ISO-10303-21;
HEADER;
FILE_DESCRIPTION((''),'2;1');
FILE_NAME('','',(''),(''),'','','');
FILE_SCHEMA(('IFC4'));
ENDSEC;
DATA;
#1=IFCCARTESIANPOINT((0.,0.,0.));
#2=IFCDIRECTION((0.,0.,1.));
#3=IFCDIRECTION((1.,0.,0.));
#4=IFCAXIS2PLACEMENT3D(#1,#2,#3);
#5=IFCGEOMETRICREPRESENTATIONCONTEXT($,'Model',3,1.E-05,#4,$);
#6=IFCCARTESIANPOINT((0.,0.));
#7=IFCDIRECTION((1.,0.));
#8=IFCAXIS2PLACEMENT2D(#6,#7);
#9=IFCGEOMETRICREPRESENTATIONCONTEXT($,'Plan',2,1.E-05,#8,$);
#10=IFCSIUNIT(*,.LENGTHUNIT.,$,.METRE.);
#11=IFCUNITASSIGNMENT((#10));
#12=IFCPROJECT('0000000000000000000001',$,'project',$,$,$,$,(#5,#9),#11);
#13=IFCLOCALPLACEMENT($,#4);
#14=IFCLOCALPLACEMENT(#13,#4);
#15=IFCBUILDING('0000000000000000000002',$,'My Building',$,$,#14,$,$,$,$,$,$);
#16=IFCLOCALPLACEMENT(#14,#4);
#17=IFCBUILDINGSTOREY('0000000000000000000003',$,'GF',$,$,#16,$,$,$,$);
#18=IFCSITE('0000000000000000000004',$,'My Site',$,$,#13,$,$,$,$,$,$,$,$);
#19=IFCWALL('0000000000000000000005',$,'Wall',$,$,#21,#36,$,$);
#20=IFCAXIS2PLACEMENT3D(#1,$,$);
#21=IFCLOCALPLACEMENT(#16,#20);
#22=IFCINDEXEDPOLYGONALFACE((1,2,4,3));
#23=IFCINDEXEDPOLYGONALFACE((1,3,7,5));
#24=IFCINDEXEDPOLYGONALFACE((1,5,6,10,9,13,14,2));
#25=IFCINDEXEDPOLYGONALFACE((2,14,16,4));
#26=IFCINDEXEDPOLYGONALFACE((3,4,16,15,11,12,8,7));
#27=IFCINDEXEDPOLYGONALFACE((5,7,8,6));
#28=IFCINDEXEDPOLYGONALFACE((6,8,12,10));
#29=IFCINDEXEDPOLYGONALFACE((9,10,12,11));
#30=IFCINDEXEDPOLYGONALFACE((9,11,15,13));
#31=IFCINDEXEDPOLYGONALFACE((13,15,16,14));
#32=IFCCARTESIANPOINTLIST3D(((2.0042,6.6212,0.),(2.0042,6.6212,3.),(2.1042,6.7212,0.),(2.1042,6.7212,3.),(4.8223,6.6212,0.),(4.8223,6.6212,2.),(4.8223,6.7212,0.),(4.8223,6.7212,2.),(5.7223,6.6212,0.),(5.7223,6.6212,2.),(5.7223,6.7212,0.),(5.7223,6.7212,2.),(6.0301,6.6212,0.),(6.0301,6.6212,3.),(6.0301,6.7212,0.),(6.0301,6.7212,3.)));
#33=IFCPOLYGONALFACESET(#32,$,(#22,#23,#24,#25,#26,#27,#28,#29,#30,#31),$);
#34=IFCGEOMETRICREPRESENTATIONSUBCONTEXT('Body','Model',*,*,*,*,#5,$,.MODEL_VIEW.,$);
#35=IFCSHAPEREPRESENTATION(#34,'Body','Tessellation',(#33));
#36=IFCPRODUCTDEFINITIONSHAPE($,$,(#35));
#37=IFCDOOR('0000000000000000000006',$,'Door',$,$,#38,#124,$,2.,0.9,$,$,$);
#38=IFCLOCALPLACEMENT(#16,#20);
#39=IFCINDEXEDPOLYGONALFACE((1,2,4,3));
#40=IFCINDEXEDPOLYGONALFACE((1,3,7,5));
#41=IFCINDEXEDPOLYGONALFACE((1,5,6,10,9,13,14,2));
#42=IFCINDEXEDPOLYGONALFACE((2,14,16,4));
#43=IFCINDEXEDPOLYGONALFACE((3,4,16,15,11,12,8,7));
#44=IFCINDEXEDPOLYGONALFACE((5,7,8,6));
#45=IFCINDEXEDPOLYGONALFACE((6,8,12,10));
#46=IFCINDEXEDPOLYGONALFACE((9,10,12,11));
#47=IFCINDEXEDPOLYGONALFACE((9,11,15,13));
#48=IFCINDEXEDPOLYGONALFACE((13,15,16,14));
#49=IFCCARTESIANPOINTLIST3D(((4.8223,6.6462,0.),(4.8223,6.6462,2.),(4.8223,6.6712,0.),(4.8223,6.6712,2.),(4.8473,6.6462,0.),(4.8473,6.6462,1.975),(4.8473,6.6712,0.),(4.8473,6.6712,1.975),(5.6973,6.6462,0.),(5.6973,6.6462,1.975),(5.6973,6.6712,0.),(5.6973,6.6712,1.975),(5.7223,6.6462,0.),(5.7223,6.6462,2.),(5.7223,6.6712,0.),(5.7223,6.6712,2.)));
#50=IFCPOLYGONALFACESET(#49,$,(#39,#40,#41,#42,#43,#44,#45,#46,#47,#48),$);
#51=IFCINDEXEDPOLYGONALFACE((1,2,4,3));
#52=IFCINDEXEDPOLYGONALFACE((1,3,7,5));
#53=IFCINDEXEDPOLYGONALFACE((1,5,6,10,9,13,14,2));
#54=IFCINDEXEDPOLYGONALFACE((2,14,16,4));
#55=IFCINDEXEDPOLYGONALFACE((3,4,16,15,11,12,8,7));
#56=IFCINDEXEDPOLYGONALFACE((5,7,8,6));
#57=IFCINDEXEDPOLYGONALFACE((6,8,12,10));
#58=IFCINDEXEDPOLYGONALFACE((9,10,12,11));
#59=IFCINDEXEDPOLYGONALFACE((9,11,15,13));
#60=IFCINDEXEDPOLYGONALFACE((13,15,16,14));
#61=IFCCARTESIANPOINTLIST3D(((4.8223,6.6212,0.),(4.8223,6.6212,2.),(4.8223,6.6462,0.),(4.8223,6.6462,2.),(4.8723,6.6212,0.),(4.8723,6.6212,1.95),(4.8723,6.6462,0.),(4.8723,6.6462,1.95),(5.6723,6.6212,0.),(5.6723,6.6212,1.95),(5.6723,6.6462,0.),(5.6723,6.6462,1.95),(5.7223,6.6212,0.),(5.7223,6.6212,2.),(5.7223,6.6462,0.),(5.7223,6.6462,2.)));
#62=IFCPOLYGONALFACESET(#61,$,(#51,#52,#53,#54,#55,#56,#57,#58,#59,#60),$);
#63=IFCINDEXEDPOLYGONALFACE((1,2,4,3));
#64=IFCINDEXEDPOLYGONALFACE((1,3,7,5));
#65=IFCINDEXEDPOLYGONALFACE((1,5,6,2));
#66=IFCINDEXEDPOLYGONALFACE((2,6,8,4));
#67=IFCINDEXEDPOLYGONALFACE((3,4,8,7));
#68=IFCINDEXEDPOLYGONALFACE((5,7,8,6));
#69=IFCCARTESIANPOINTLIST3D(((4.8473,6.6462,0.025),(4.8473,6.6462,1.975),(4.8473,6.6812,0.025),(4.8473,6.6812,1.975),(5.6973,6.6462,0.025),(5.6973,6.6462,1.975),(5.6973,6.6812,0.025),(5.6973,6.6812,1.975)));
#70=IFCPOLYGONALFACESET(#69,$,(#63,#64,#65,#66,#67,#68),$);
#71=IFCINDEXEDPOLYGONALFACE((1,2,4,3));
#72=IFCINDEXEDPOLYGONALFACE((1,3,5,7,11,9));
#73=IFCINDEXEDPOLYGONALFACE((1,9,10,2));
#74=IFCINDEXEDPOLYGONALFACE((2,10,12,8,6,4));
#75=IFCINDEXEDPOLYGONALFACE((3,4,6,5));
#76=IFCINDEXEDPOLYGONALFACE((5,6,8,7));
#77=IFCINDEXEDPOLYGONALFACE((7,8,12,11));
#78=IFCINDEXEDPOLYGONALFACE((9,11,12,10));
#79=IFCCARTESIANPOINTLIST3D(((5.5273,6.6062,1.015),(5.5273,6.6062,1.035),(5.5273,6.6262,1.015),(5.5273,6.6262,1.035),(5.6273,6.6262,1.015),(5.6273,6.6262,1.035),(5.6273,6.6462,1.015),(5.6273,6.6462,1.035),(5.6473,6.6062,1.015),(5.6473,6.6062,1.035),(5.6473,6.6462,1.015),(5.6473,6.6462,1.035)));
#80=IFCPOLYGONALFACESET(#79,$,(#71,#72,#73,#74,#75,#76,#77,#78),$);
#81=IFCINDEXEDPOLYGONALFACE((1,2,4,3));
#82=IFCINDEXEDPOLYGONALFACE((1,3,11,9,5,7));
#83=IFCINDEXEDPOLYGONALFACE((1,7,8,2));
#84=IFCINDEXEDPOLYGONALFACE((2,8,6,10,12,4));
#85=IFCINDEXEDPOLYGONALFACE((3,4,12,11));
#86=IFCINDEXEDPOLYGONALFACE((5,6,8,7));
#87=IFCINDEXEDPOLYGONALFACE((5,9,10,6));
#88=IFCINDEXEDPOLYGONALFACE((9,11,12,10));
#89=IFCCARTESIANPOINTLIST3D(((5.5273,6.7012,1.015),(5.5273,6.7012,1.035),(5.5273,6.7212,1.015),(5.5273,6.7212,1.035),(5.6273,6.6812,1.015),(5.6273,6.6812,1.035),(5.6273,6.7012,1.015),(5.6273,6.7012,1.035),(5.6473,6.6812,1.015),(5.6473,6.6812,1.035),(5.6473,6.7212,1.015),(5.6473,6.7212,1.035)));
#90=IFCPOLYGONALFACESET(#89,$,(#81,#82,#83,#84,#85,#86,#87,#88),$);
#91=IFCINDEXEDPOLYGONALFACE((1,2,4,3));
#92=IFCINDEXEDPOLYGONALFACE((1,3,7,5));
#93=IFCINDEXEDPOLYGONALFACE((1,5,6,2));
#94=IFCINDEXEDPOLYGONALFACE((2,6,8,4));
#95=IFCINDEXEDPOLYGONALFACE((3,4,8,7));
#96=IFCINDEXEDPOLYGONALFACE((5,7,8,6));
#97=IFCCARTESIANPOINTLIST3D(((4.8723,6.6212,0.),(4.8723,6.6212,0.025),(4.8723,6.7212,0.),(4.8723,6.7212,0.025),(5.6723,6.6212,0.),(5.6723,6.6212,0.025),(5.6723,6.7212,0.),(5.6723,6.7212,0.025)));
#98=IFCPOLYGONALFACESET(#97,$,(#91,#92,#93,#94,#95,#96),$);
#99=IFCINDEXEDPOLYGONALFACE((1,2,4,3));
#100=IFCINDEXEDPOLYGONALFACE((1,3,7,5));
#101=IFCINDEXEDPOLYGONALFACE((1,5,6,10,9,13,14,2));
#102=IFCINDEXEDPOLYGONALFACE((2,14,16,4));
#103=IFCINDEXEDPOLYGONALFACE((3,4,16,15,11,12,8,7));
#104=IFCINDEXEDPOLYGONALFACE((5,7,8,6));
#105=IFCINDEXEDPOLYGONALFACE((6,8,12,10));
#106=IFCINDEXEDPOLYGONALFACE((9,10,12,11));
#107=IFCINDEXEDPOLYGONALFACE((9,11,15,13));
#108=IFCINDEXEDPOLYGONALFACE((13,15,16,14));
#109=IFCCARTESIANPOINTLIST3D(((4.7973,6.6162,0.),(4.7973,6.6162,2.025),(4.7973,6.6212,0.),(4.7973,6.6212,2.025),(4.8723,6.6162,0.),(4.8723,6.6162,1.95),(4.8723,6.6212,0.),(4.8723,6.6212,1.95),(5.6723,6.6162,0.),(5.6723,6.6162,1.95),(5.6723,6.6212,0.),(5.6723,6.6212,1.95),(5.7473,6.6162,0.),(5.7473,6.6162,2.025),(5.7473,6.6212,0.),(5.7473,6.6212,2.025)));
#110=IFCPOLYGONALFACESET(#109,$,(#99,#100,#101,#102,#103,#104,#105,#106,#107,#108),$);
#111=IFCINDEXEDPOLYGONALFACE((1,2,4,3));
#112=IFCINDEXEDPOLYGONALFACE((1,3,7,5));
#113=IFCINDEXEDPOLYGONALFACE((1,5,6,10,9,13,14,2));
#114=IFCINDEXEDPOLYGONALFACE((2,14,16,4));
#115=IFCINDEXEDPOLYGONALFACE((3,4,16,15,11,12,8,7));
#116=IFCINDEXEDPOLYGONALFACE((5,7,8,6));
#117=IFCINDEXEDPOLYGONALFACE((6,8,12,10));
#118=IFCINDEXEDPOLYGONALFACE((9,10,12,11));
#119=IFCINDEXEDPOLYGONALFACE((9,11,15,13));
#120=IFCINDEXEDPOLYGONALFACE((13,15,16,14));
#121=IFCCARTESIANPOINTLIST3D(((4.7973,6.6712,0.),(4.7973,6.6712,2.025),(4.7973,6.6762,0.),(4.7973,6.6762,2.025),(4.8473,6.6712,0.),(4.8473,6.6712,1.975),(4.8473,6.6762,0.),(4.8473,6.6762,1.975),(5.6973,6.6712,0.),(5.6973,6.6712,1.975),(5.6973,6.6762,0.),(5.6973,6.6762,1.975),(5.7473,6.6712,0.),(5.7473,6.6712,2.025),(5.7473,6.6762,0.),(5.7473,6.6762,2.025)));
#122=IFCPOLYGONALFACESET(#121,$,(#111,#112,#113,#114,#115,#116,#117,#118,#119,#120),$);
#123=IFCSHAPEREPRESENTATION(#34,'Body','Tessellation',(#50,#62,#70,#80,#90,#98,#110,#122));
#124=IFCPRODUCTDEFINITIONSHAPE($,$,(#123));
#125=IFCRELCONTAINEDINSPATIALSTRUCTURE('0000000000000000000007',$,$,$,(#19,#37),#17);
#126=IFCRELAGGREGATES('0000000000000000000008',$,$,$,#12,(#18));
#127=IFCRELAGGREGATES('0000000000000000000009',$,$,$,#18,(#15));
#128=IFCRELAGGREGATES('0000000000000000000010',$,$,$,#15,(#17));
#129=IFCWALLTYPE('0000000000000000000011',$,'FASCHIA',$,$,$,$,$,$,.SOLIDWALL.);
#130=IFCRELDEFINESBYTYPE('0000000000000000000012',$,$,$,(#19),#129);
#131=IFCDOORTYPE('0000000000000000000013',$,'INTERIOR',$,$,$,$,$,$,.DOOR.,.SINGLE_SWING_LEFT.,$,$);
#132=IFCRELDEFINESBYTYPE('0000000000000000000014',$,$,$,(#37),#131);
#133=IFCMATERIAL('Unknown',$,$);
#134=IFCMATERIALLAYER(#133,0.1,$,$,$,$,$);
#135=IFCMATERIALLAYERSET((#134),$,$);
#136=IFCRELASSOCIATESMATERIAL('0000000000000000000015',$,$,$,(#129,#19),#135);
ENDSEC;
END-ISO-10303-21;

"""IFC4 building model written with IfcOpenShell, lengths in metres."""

from ifc_helpers import new_model, entity, si_unit, frame, origin_with_axes, origin_2d_with_axis, place, context, subcontext, project, spatial, line, indexed_curve, outline, extrude, shape, source, transform, mapped, material, layer, layer_set, layer_usage, type_object, type_shapes, element, fill, save


model = new_model("IFC4")

# Units and contexts
model_context = context("Model", 3, precision=1e-05, world=origin_with_axes())
plan_context = context("Plan", 2, precision=1e-05, world=origin_2d_with_axis())
body_context_1 = subcontext(model_context, "Body", "Model", "MODEL_VIEW")
body_context_2 = subcontext(plan_context, "Body", "Plan", "PLAN_VIEW")
ifc_project = project(units=[si_unit("LENGTHUNIT", "METRE")], contexts=[model_context, plan_context])

# Site, building, storey
site_placement = place(None, origin_with_axes())
site = spatial("IfcSite", under=ifc_project, at=site_placement, Name="My Site")
building_placement = place(site_placement, origin_with_axes())
building = spatial("IfcBuilding", under=site, at=building_placement, Name="My Building")
storey_placement = place(building_placement, origin_with_axes())
storey = spatial("IfcBuildingStorey", under=building, at=storey_placement, Name="GF")

# Shared definitions
ifc_material = material(Name="Unknown")

# Shared definitions
ifc_layer_1 = layer(ifc_material, 0.1)
ifc_layer_set_1 = layer_set([ifc_layer_1])
wall_type_1 = type_object("IfcWallType", Name="FASCHIA", PredefinedType="SOLIDWALL", material=ifc_layer_set_1)

# Wall, opening, door
ifc_layer_usage_1 = layer_usage(ifc_layer_set_1, "AXIS2", "POSITIVE", 0.0)
wall_1_placement = place(storey_placement, frame((2.0042, 6.6212, 0.0), z_axis=(0.0, 0.0, 1.0), x_axis=(1.0, 0.0, 0.0)))
wall_1 = element("IfcWall", 1, at=wall_1_placement, inside=storey, type_object=wall_type_1, material=ifc_layer_usage_1, Name="Wall", context=body_context_1, shape_type="SweptSolid", body=[
    extrude(outline(indexed_curve([(0.0, 0.0), (0.1, 0.1), (4.0259, 0.1), (4.0259, 0.0)], segments=[line(1, 2, 3, 4, 1)])), origin_with_axes(), (0.0, 0.0, 1.0), 3.0),
])
shared_shape_1 = source(origin_with_axes(), body_context_1, "Body", "SweptSolid", [
    extrude(outline(indexed_curve([(0.0, 0.0), (0.9, 0.0), (0.9, 2.0), (0.0, 2.0)], segments=[line(1, 2, 3, 4, 1)])), frame((0.0, -0.6, 0.0), z_axis=(0.0, -1.0, 0.0), x_axis=(1.0, 0.0, 0.0)), (0.0, 0.0, -1.0), 1.2),
])
opening_1_placement = place(wall_1_placement, frame((2.8181, 0.0, 0.0), z_axis=(0.0, 0.0, 1.0), x_axis=(1.0, 0.0, 0.0)))
opening_1 = element("IfcOpeningElement", 2, at=opening_1_placement, cuts=wall_1, PredefinedType="OPENING", context=body_context_1, shape_type="MappedRepresentation", body=[
    mapped(shared_shape_1, transform((0.0, 0.0, 0.0), x_axis=(1.0, 0.0, 0.0), y_axis=(0.0, 1.0, 0.0), z_axis=(0.0, 0.0, 1.0), scale=1.0)),
])
door_type_1 = type_object("IfcDoorType", Name="INTERIOR", OperationType="SINGLE_SWING_LEFT", PredefinedType="DOOR")
shared_shape_2 = source(origin_with_axes(), body_context_1, "Body", "SweptSolid", [
    extrude(outline(indexed_curve([(0.0, 0.0), (0.0, 2.0), (0.9, 2.0), (0.9, 0.0), (0.875, 0.0), (0.875, 1.975), (0.025, 1.975), (0.025, 0.0)], segments=[line(1, 2, 3, 4, 5, 6, 7, 8, 1)])), frame((0.0, 0.025, 0.0), z_axis=(0.0, -1.0, 0.0), x_axis=(1.0, 0.0, 0.0)), (0.0, 0.0, -1.0), 0.025),
    extrude(outline(indexed_curve([(0.0, 0.0), (0.0, 2.0), (0.9, 2.0), (0.9, 0.0), (0.85, 0.0), (0.85, 1.95), (0.05, 1.95), (0.05, 0.0)], segments=[line(1, 2, 3, 4, 5, 6, 7, 8, 1)])), frame((0.0, 0.0, 0.0), z_axis=(0.0, -1.0, 0.0), x_axis=(1.0, 0.0, 0.0)), (0.0, 0.0, -1.0), 0.025),
    extrude(outline(indexed_curve([(0.0, 0.0), (0.85, 0.0), (0.85, 0.035), (0.0, 0.035)], segments=[line(1, 2, 3, 4, 1)])), frame((0.025, 0.025, 0.025), z_axis=(0.0, 0.0, 1.0), x_axis=(1.0, 0.0, 0.0)), (0.0, 0.0, 1.0), 1.95),
    extrude(outline(indexed_curve([(0.0, 0.0), (0.0, -0.04), (-0.12, -0.04), (-0.12, -0.02), (-0.02, -0.02), (-0.02, 0.0)], segments=[line(1, 2, 3, 4, 5, 6, 1)])), frame((0.825, 0.025, 1.015), z_axis=(0.0, 0.0, 1.0), x_axis=(1.0, 0.0, 0.0)), (0.0, 0.0, 1.0), 0.02),
    extrude(outline(indexed_curve([(0.0, 0.0), (0.0, 0.04), (-0.12, 0.04), (-0.12, 0.02), (-0.02, 0.02), (-0.02, 0.0)], segments=[line(1, 2, 3, 4, 5, 6, 1)])), frame((0.825, 0.06, 1.015), z_axis=(0.0, 0.0, 1.0), x_axis=(1.0, 0.0, 0.0)), (0.0, 0.0, 1.0), 0.02),
    extrude(outline(indexed_curve([(0.0, 0.0), (0.8, 0.0), (0.8, 0.1), (0.0, 0.1)], segments=[line(1, 2, 3, 4, 1)])), frame((0.05, 0.0, 0.0), z_axis=(0.0, 0.0, 1.0), x_axis=(1.0, 0.0, 0.0)), (0.0, 0.0, 1.0), 0.025),
    extrude(outline(indexed_curve([(0.0, 0.0), (0.0, 2.025), (0.95, 2.025), (0.95, 0.0), (0.875, 0.0), (0.875, 1.95), (0.075, 1.95), (0.075, 0.0)], segments=[line(1, 2, 3, 4, 5, 6, 7, 8, 1)])), frame((-0.025, -0.005, 0.0), z_axis=(0.0, -1.0, 0.0), x_axis=(1.0, 0.0, 0.0)), (0.0, 0.0, -1.0), 0.005),
    extrude(outline(indexed_curve([(0.0, 0.0), (0.0, 2.025), (0.95, 2.025), (0.95, 0.0), (0.9, 0.0), (0.9, 1.975), (0.05, 1.975), (0.05, 0.0)], segments=[line(1, 2, 3, 4, 5, 6, 7, 8, 1)])), frame((-0.025, 0.05, 0.0), z_axis=(0.0, -1.0, 0.0), x_axis=(1.0, 0.0, 0.0)), (0.0, 0.0, -1.0), 0.005),
])
shared_shape_3 = source(origin_with_axes(), body_context_2, "Body", "Curve2D", [
    entity("IfcIndexedPolyCurve", entity("IfcCartesianPointList2D", [[0.0, 0.0], [0.0, 0.05], [0.025, 0.05], [0.025, 0.025], [0.05, 0.025], [0.05, 0.0]]), [entity("IfcLineIndex", [1, 2, 3, 4, 5, 6, 1])]),
    entity("IfcIndexedPolyCurve", entity("IfcCartesianPointList2D", [[0.9, 0.0], [0.9, 0.05], [0.875, 0.05], [0.875, 0.025], [0.85, 0.025], [0.85, 0.0]]), [entity("IfcLineIndex", [1, 2, 3, 4, 5, 6, 1])]),
    entity("IfcTrimmedCurve", entity("IfcEllipse", entity("IfcAxis2Placement2D", entity("IfcCartesianPoint", [0.06, 0.05]), entity("IfcDirection", [1.0, 0.0])), 0.815, 0.85), [entity("IfcCartesianPoint", [0.875, 0.05])], [entity("IfcCartesianPoint", [0.06, 0.9])], True, "CARTESIAN"),
    entity("IfcIndexedPolyCurve", entity("IfcCartesianPointList2D", [[0.025, 0.05], [0.06, 0.05], [0.06, 0.9], [0.025, 0.9]]), [entity("IfcLineIndex", [1, 2, 3, 4, 1])]),
])
type_shapes(door_type_1, [shared_shape_2, shared_shape_3])
door_1_placement = place(opening_1_placement, origin_with_axes())
door_1 = element("IfcDoor", 3, at=door_1_placement, inside=storey, type_object=door_type_1, Name="Door", OverallHeight=2.0, OverallWidth=0.9, shapes=[
    shape(body_context_1, "Body", "MappedRepresentation", [mapped(shared_shape_2, transform((0.0, 0.0, 0.0), x_axis=(1.0, 0.0, 0.0), y_axis=(0.0, 1.0, 0.0), z_axis=(0.0, 0.0, 1.0), scale=1.0))]),
    shape(body_context_2, "Body", "MappedRepresentation", [mapped(shared_shape_3, transform((0.0, 0.0, 0.0), x_axis=(1.0, 0.0, 0.0), y_axis=(0.0, 1.0, 0.0), z_axis=(0.0, 0.0, 1.0), scale=1.0))]),
])
fill(opening_1, door_1)

save(model, "model.ifc")
